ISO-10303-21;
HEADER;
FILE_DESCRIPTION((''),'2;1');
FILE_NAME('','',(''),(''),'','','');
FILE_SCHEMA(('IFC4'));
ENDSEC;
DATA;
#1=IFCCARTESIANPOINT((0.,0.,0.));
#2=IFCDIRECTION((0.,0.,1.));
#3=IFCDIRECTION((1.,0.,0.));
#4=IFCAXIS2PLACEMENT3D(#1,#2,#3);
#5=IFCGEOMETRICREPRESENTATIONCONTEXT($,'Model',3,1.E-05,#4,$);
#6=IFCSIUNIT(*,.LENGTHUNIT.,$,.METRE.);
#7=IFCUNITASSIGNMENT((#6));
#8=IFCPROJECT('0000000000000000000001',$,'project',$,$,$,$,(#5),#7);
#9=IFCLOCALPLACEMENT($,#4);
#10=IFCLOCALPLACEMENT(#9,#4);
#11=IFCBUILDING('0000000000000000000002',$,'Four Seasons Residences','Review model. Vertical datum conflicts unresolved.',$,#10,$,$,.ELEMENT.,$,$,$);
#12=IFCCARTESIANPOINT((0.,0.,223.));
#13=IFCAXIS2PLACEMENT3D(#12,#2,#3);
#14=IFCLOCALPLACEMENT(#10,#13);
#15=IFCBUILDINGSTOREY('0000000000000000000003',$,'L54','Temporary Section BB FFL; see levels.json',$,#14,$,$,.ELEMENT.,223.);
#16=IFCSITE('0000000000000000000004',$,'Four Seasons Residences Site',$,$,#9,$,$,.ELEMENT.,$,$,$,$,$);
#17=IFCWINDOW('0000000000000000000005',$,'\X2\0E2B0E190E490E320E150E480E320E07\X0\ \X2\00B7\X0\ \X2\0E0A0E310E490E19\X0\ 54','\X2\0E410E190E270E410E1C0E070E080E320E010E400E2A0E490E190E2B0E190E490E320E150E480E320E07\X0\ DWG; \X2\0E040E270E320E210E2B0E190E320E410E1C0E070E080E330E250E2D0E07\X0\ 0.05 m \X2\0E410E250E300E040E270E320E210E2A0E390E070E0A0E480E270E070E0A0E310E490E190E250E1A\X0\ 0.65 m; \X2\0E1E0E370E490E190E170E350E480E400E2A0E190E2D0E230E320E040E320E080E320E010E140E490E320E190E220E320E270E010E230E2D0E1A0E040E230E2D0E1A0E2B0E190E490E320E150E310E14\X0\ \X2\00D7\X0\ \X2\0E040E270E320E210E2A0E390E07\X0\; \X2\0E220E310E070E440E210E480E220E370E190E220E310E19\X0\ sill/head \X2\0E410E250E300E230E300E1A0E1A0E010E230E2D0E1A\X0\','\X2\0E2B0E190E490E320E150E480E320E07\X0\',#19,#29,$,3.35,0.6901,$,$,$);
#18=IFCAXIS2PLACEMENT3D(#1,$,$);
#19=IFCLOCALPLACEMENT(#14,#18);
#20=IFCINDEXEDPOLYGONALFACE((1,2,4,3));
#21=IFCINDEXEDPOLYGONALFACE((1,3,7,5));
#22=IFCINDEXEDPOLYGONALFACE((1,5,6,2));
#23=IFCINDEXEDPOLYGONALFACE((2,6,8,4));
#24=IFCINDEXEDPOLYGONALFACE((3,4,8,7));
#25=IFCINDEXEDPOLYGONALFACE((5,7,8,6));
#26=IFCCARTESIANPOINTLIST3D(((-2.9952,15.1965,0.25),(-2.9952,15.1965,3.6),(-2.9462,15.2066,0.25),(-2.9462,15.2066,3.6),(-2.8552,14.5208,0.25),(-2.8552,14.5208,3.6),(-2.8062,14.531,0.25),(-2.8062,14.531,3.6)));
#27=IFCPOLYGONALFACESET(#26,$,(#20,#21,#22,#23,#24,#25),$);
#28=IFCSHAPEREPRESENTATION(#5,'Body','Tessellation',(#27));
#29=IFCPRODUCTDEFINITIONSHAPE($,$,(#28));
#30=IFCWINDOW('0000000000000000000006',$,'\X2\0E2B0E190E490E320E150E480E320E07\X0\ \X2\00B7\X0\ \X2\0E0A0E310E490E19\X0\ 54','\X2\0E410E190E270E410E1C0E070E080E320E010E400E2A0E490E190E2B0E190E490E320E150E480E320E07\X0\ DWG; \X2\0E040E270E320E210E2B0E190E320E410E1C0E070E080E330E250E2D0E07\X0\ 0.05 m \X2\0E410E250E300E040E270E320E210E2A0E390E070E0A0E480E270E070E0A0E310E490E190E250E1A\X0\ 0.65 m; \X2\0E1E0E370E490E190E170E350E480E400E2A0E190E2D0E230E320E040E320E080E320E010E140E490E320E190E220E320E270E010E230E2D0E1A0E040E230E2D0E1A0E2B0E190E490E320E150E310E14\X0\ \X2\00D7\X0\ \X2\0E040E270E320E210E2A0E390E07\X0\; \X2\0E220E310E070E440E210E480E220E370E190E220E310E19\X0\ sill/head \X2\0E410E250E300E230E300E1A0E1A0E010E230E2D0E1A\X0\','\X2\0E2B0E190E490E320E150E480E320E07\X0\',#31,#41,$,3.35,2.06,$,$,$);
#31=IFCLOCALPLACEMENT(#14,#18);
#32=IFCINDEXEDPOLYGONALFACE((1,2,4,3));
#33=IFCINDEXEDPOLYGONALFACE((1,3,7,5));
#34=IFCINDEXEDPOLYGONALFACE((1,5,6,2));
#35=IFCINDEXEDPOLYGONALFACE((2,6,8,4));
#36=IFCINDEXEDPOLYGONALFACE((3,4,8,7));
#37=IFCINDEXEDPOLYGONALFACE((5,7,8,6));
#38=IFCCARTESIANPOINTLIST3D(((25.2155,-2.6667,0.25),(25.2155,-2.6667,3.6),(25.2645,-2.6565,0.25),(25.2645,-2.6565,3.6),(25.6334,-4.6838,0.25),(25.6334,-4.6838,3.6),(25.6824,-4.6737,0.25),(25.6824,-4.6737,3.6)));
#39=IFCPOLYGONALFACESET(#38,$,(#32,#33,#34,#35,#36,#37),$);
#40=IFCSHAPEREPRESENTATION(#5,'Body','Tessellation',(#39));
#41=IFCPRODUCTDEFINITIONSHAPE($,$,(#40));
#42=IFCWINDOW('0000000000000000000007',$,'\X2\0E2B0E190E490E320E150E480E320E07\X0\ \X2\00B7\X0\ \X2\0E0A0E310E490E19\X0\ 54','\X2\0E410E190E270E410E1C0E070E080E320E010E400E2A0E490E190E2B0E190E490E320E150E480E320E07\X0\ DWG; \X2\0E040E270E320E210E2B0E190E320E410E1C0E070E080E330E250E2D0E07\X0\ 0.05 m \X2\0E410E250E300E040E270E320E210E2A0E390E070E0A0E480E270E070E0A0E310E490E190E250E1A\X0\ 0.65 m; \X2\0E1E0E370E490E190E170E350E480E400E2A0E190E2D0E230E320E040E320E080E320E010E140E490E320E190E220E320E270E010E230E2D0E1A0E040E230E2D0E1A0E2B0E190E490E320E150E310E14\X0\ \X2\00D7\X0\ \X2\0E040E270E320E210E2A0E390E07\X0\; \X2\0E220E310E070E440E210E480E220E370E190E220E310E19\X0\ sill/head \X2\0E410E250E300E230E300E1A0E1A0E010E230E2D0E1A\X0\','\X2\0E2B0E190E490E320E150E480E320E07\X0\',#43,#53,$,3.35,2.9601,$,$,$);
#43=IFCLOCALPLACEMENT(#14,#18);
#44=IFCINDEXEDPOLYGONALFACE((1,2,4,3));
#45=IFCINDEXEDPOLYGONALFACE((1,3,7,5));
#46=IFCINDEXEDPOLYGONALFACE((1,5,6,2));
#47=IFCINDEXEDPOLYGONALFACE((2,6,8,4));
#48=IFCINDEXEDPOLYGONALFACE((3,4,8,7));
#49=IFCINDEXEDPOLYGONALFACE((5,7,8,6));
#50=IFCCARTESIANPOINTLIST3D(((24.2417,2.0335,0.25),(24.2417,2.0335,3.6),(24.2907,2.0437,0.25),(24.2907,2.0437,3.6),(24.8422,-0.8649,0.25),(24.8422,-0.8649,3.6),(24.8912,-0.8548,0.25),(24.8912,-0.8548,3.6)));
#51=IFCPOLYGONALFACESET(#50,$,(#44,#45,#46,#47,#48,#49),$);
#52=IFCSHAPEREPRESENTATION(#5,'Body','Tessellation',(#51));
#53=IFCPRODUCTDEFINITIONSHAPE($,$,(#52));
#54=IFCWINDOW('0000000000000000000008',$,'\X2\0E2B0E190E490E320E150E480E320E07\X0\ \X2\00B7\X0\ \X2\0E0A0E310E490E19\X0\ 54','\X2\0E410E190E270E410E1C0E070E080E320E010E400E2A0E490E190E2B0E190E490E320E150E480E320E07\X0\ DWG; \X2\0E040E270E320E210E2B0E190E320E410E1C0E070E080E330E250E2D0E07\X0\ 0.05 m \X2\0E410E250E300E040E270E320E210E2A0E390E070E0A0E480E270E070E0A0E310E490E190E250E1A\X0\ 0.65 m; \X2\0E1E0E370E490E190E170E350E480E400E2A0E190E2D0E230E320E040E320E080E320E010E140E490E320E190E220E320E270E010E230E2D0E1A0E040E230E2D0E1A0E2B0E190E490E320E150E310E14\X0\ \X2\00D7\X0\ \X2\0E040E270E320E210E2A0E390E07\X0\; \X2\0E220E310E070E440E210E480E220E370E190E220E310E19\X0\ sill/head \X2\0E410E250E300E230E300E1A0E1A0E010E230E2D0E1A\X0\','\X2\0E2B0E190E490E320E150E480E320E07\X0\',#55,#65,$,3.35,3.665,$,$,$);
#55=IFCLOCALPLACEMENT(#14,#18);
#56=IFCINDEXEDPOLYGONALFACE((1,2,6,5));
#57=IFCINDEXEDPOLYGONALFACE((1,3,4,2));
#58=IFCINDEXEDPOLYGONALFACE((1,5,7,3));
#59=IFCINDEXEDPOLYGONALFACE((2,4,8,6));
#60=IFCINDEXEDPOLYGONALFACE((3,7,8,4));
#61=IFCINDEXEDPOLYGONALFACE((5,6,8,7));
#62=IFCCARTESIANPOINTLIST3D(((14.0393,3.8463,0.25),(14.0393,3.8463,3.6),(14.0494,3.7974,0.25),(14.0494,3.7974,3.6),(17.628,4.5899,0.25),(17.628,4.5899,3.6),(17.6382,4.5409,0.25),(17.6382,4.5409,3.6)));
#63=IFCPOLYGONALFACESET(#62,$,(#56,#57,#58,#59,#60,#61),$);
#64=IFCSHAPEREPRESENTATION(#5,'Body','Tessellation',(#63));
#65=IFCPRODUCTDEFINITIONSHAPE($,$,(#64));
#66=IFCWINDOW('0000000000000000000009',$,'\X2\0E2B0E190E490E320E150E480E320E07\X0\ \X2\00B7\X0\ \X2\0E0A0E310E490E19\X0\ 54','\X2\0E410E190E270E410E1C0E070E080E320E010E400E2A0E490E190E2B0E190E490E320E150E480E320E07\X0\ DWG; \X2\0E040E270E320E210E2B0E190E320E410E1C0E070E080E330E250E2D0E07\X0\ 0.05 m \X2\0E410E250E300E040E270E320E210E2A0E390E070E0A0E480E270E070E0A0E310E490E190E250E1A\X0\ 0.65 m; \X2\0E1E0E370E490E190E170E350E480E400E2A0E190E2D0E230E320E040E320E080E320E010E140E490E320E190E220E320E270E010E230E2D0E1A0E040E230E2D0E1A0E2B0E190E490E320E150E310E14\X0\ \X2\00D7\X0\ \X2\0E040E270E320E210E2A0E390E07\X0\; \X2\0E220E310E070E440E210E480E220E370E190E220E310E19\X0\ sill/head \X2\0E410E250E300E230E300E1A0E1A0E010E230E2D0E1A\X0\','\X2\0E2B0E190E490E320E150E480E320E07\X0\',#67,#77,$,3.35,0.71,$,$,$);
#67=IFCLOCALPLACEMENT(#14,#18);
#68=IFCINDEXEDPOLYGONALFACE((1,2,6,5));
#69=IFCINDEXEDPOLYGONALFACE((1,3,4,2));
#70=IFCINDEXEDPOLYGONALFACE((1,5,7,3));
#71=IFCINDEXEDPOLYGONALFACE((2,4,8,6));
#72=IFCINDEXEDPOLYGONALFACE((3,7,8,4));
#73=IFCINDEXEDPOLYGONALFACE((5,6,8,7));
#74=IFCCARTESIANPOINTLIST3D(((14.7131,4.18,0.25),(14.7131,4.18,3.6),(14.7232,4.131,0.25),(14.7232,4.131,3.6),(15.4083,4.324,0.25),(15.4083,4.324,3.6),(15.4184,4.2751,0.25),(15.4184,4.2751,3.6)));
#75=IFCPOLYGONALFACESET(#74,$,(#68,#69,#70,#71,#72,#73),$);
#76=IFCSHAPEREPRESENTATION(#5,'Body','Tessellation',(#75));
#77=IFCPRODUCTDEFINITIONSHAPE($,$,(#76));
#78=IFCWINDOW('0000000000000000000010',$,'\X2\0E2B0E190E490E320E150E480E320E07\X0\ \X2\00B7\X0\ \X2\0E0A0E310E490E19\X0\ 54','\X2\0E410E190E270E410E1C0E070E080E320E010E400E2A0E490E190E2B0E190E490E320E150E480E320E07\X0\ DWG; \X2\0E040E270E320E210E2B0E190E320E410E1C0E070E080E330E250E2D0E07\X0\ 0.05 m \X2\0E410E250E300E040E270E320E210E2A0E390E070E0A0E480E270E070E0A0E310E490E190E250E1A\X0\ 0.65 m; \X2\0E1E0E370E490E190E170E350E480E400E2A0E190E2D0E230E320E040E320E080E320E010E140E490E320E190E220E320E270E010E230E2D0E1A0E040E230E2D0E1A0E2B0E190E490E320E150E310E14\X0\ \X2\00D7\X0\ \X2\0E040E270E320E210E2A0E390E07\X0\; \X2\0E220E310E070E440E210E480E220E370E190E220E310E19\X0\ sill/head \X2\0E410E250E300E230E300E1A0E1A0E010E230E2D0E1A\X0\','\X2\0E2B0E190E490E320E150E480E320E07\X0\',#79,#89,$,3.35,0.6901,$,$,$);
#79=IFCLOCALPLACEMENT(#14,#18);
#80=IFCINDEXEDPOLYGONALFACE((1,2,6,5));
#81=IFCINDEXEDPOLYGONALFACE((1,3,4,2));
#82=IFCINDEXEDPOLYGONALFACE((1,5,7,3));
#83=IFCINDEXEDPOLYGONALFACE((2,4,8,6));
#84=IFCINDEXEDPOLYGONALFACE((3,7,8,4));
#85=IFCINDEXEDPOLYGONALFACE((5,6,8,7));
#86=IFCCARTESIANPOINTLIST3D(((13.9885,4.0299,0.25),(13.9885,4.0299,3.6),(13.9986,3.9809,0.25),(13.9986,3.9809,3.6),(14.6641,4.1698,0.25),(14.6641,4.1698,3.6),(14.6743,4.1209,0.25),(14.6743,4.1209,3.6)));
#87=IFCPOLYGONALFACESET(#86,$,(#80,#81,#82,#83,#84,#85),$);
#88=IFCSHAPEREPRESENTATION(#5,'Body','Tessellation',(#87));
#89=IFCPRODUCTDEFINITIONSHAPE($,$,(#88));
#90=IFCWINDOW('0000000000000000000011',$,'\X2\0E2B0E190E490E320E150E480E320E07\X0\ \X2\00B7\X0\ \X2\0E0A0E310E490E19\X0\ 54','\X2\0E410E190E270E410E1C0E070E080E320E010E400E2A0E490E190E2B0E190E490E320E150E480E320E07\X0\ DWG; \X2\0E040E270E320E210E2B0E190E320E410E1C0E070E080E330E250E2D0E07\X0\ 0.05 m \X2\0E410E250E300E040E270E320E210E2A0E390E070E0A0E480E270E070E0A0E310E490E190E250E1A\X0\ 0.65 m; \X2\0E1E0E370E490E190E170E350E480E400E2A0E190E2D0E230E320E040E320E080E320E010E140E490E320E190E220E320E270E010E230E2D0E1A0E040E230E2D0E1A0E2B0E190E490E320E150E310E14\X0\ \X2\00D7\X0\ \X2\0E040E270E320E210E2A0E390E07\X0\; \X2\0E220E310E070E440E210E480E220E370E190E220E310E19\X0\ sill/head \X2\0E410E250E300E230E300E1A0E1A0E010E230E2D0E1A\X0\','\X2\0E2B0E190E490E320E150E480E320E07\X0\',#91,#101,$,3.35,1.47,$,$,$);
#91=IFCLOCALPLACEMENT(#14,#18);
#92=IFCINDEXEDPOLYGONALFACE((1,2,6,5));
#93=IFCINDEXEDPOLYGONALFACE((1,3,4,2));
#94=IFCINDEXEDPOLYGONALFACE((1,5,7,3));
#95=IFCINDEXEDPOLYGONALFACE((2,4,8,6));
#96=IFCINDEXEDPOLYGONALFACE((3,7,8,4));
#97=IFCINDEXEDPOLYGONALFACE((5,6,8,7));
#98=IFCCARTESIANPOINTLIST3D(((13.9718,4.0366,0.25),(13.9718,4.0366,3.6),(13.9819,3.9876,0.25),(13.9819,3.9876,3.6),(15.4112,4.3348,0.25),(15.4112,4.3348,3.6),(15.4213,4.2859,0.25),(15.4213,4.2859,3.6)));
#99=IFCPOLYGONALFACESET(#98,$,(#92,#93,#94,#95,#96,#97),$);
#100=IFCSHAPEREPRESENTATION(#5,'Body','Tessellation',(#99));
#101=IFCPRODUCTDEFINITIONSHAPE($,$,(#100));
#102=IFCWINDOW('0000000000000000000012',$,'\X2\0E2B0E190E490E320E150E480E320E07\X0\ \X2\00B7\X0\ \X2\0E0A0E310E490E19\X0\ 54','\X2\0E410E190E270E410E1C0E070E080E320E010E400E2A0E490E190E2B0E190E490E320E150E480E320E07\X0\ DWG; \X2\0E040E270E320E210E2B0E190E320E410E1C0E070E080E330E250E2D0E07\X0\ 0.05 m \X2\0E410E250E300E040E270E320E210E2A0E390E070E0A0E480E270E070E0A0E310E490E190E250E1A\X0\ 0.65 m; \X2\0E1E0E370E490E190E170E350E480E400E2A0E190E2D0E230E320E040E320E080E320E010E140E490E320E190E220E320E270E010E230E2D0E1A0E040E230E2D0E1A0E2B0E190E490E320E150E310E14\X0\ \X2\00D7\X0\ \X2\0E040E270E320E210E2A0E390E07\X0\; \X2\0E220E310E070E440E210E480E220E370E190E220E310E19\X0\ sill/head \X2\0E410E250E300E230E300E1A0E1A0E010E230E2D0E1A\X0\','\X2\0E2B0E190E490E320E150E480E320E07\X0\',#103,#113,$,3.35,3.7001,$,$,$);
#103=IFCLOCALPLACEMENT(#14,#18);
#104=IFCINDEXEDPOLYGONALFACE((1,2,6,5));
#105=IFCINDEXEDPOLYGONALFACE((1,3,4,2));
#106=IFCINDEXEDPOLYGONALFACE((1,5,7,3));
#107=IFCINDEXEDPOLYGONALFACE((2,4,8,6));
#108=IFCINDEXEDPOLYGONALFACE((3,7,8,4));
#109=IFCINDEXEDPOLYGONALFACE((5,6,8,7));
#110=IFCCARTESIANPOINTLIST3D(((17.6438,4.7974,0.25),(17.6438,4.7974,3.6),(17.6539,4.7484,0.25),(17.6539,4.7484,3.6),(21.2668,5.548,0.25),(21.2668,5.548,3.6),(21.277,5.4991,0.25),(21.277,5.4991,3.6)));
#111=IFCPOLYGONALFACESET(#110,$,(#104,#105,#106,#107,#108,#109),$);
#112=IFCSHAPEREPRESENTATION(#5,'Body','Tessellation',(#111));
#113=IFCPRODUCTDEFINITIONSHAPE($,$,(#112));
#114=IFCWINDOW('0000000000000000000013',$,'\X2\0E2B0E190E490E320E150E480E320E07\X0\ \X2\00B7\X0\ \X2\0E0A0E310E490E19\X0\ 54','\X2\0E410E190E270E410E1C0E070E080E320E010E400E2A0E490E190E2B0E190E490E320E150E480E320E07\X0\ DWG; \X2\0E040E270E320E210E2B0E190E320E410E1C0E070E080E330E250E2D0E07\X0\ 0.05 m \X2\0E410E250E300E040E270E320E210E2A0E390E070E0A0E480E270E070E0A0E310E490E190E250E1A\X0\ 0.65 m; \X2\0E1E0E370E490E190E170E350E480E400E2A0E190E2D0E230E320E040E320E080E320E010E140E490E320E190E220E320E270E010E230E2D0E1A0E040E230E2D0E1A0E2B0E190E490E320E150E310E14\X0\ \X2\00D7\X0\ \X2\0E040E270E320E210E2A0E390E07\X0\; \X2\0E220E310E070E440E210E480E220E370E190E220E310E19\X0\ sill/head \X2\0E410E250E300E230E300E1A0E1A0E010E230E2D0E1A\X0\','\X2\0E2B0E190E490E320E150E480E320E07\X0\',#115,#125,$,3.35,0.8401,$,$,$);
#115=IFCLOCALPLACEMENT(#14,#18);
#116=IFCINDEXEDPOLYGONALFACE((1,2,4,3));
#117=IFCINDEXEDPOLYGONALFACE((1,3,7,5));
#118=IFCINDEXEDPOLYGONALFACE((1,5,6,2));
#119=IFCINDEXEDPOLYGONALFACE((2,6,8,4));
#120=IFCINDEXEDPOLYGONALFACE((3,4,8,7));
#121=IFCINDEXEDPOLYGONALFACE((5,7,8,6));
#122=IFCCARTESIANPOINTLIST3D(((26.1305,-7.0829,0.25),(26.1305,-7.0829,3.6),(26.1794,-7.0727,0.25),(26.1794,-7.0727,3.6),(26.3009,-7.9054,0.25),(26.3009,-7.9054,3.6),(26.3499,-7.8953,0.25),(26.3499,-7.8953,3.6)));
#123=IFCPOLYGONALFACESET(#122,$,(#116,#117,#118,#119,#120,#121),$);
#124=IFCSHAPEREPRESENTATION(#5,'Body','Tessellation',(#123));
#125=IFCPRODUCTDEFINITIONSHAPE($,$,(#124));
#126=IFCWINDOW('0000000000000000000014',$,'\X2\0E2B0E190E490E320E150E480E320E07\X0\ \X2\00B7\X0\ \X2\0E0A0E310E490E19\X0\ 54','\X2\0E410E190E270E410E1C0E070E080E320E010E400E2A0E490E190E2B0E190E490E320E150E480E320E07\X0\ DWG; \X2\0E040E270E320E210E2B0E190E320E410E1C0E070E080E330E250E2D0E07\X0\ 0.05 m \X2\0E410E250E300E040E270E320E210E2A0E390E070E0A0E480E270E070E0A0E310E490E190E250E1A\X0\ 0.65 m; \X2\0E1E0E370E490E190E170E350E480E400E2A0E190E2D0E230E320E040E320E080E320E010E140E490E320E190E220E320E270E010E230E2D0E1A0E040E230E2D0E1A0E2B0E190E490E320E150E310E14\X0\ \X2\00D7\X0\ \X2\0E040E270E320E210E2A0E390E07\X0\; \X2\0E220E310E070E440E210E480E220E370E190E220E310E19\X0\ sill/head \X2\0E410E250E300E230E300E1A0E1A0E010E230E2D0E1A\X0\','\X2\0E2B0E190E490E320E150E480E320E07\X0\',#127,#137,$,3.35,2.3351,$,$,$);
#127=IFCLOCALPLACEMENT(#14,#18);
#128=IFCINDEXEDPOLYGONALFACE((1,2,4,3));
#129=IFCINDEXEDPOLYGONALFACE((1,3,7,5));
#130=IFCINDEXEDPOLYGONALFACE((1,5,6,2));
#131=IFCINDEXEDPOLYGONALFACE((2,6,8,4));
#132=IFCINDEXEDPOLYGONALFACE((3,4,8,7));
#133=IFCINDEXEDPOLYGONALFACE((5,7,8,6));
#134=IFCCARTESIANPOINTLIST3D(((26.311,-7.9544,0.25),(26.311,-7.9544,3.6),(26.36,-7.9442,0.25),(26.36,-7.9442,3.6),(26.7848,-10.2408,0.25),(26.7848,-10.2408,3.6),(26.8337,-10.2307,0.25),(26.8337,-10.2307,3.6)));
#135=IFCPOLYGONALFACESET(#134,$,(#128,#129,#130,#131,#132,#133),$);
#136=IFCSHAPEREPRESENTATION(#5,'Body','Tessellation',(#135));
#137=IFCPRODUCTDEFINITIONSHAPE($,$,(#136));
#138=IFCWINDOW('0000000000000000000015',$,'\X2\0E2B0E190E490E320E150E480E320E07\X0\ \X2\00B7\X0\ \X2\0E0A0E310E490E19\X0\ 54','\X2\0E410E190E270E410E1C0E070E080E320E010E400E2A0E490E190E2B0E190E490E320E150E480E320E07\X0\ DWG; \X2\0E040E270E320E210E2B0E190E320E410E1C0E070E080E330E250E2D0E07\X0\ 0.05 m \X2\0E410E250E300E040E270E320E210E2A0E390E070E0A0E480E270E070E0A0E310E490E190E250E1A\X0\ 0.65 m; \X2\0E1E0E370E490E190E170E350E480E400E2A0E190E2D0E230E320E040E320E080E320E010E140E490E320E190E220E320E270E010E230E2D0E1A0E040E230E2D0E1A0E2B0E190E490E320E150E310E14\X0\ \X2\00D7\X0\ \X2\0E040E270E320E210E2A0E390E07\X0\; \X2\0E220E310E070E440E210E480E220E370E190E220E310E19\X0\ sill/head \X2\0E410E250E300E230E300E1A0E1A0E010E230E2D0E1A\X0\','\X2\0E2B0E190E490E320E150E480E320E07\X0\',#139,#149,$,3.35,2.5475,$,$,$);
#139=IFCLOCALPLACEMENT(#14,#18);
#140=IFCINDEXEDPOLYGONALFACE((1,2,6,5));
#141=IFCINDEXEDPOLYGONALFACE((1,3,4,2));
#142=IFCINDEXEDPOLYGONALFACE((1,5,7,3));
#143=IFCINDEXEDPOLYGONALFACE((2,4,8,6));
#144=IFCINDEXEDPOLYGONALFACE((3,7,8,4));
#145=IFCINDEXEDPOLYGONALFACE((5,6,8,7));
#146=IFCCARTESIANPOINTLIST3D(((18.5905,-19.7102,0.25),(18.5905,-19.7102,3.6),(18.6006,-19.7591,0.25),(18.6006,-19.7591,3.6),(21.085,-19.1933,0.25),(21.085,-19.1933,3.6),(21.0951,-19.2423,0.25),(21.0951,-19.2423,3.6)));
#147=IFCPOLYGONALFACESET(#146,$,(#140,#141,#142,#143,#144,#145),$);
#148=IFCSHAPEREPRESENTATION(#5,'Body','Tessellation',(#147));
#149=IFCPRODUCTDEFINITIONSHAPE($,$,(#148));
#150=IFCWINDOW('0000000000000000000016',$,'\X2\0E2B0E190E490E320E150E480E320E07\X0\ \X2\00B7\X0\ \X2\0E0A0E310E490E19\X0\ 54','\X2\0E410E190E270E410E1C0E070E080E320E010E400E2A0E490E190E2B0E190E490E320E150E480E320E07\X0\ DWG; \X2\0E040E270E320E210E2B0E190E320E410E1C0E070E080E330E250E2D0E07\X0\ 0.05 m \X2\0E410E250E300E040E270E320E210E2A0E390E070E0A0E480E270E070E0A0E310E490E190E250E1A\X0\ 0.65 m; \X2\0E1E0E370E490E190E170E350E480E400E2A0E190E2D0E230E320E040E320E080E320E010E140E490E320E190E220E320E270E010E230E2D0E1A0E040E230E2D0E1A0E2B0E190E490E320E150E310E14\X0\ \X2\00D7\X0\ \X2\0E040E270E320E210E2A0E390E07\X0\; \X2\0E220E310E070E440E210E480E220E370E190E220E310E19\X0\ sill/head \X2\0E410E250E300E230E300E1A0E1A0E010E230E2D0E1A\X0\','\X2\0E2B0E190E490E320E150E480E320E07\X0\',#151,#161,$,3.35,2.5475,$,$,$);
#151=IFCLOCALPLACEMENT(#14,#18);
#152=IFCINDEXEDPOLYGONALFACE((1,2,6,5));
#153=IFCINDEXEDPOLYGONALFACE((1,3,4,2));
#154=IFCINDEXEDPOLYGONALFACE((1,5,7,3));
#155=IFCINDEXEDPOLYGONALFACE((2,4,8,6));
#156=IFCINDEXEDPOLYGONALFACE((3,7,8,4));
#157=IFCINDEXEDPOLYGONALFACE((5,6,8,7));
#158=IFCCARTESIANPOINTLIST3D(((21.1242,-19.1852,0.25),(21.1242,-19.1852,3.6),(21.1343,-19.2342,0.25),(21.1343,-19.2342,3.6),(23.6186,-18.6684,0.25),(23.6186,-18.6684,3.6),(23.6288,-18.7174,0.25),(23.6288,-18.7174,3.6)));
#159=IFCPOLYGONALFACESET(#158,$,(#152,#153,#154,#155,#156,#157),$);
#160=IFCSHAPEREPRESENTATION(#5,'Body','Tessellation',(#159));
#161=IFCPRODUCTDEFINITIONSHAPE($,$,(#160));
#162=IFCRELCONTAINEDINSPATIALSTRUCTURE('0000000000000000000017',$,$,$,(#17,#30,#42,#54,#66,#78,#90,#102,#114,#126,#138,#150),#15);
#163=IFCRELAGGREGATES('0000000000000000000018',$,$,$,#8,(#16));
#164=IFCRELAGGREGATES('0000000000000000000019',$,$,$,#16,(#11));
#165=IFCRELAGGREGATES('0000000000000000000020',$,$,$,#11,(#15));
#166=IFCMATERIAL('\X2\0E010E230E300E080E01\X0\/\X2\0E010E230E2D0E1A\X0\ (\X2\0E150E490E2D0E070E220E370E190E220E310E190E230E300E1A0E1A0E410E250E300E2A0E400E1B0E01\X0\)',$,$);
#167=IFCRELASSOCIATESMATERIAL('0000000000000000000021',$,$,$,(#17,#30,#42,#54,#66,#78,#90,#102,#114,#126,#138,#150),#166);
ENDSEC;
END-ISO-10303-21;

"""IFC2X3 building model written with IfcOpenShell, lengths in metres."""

from ifc_helpers import new_model, si_unit, frame, origin_with_axes, place, context, project, spatial, polyline, outline, extrude, material, element, save


model = new_model("IFC2X3")

# Units and contexts
model_context = context("Model", 3, precision=1e-05, world=origin_with_axes())
ifc_project = project(units=[si_unit("LENGTHUNIT", "METRE")], contexts=[model_context])

# Site, building, storey
site_placement = place(None, origin_with_axes())
site = spatial("IfcSite", under=ifc_project, at=site_placement, Name="Four Seasons Residences Site", CompositionType="ELEMENT")
building_placement = place(site_placement, origin_with_axes())
building = spatial("IfcBuilding", under=site, at=building_placement, Name="Four Seasons Residences", Description="Review model. Vertical datum conflicts unresolved.", CompositionType="ELEMENT")
storey_placement = place(building_placement, frame((0.0, 0.0, 223.0), z_axis=(0.0, 0.0, 1.0), x_axis=(1.0, 0.0, 0.0)))
storey = spatial("IfcBuildingStorey", under=building, at=storey_placement, Name="L54", Description="Temporary Section BB FFL; see levels.json", CompositionType="ELEMENT", Elevation=223.0)

# Windows
ifc_material = material(Name="กระจก/กรอบ (ต้องยืนยันระบบและสเปก)")
window_1_placement = place(storey_placement, origin_with_axes())
element("IfcWindow", 1, at=window_1_placement, inside=storey, material=ifc_material, Name="หน้าต่าง · ชั้น 54", Description="แนวแผงจากเส้นหน้าต่าง DWG; ความหนาแผงจำลอง 0.05 m และความสูงช่วงชั้นลบ 0.65 m; พื้นที่เสนอราคาจากด้านยาวกรอบครอบหน้าตัด × ความสูง; ยังไม่ยืนยัน sill/head และระบบกรอบ", ObjectType="หน้าต่าง", OverallHeight=3.35, OverallWidth=0.6901, context=model_context, shape_type="SweptSolid", body=[
    extrude(outline(polyline([(-2.9952, 15.1965), (-2.9462, 15.2066), (-2.8062, 14.531), (-2.8552, 14.5208), (-2.9952, 15.1965)])), frame((0.0, 0.0, 0.25), z_axis=(0.0, 0.0, 1.0), x_axis=(1.0, 0.0, 0.0)), (0.0, 0.0, 1.0), 3.35),
])
window_2_placement = place(storey_placement, origin_with_axes())
element("IfcWindow", 2, at=window_2_placement, inside=storey, material=ifc_material, Name="หน้าต่าง · ชั้น 54", Description="แนวแผงจากเส้นหน้าต่าง DWG; ความหนาแผงจำลอง 0.05 m และความสูงช่วงชั้นลบ 0.65 m; พื้นที่เสนอราคาจากด้านยาวกรอบครอบหน้าตัด × ความสูง; ยังไม่ยืนยัน sill/head และระบบกรอบ", ObjectType="หน้าต่าง", OverallHeight=3.35, OverallWidth=2.06, context=model_context, shape_type="SweptSolid", body=[
    extrude(outline(polyline([(25.2155, -2.6667), (25.2645, -2.6565), (25.6824, -4.6737), (25.6334, -4.6838), (25.2155, -2.6667)])), frame((0.0, 0.0, 0.25), z_axis=(0.0, 0.0, 1.0), x_axis=(1.0, 0.0, 0.0)), (0.0, 0.0, 1.0), 3.35),
])
window_3_placement = place(storey_placement, origin_with_axes())
element("IfcWindow", 3, at=window_3_placement, inside=storey, material=ifc_material, Name="หน้าต่าง · ชั้น 54", Description="แนวแผงจากเส้นหน้าต่าง DWG; ความหนาแผงจำลอง 0.05 m และความสูงช่วงชั้นลบ 0.65 m; พื้นที่เสนอราคาจากด้านยาวกรอบครอบหน้าตัด × ความสูง; ยังไม่ยืนยัน sill/head และระบบกรอบ", ObjectType="หน้าต่าง", OverallHeight=3.35, OverallWidth=2.9601, context=model_context, shape_type="SweptSolid", body=[
    extrude(outline(polyline([(24.2417, 2.0335), (24.2907, 2.0437), (24.8912, -0.8548), (24.8422, -0.8649), (24.2417, 2.0335)])), frame((0.0, 0.0, 0.25), z_axis=(0.0, 0.0, 1.0), x_axis=(1.0, 0.0, 0.0)), (0.0, 0.0, 1.0), 3.35),
])
window_4_placement = place(storey_placement, origin_with_axes())
element("IfcWindow", 4, at=window_4_placement, inside=storey, material=ifc_material, Name="หน้าต่าง · ชั้น 54", Description="แนวแผงจากเส้นหน้าต่าง DWG; ความหนาแผงจำลอง 0.05 m และความสูงช่วงชั้นลบ 0.65 m; พื้นที่เสนอราคาจากด้านยาวกรอบครอบหน้าตัด × ความสูง; ยังไม่ยืนยัน sill/head และระบบกรอบ", ObjectType="หน้าต่าง", OverallHeight=3.35, OverallWidth=3.665, context=model_context, shape_type="SweptSolid", body=[
    extrude(outline(polyline([(14.0494, 3.7974), (14.0393, 3.8463), (17.628, 4.5899), (17.6382, 4.5409), (14.0494, 3.7974)])), frame((0.0, 0.0, 0.25), z_axis=(0.0, 0.0, 1.0), x_axis=(1.0, 0.0, 0.0)), (0.0, 0.0, 1.0), 3.35),
])
window_5_placement = place(storey_placement, origin_with_axes())
element("IfcWindow", 5, at=window_5_placement, inside=storey, material=ifc_material, Name="หน้าต่าง · ชั้น 54", Description="แนวแผงจากเส้นหน้าต่าง DWG; ความหนาแผงจำลอง 0.05 m และความสูงช่วงชั้นลบ 0.65 m; พื้นที่เสนอราคาจากด้านยาวกรอบครอบหน้าตัด × ความสูง; ยังไม่ยืนยัน sill/head และระบบกรอบ", ObjectType="หน้าต่าง", OverallHeight=3.35, OverallWidth=0.71, context=model_context, shape_type="SweptSolid", body=[
    extrude(outline(polyline([(14.7232, 4.131), (14.7131, 4.18), (15.4083, 4.324), (15.4184, 4.2751), (14.7232, 4.131)])), frame((0.0, 0.0, 0.25), z_axis=(0.0, 0.0, 1.0), x_axis=(1.0, 0.0, 0.0)), (0.0, 0.0, 1.0), 3.35),
])
window_6_placement = place(storey_placement, origin_with_axes())
element("IfcWindow", 6, at=window_6_placement, inside=storey, material=ifc_material, Name="หน้าต่าง · ชั้น 54", Description="แนวแผงจากเส้นหน้าต่าง DWG; ความหนาแผงจำลอง 0.05 m และความสูงช่วงชั้นลบ 0.65 m; พื้นที่เสนอราคาจากด้านยาวกรอบครอบหน้าตัด × ความสูง; ยังไม่ยืนยัน sill/head และระบบกรอบ", ObjectType="หน้าต่าง", OverallHeight=3.35, OverallWidth=0.6901, context=model_context, shape_type="SweptSolid", body=[
    extrude(outline(polyline([(13.9986, 3.9809), (13.9885, 4.0299), (14.6641, 4.1698), (14.6743, 4.1209), (13.9986, 3.9809)])), frame((0.0, 0.0, 0.25), z_axis=(0.0, 0.0, 1.0), x_axis=(1.0, 0.0, 0.0)), (0.0, 0.0, 1.0), 3.35),
])
window_7_placement = place(storey_placement, origin_with_axes())
element("IfcWindow", 7, at=window_7_placement, inside=storey, material=ifc_material, Name="หน้าต่าง · ชั้น 54", Description="แนวแผงจากเส้นหน้าต่าง DWG; ความหนาแผงจำลอง 0.05 m และความสูงช่วงชั้นลบ 0.65 m; พื้นที่เสนอราคาจากด้านยาวกรอบครอบหน้าตัด × ความสูง; ยังไม่ยืนยัน sill/head และระบบกรอบ", ObjectType="หน้าต่าง", OverallHeight=3.35, OverallWidth=1.47, context=model_context, shape_type="SweptSolid", body=[
    extrude(outline(polyline([(13.9819, 3.9876), (13.9718, 4.0366), (15.4112, 4.3348), (15.4213, 4.2859), (13.9819, 3.9876)])), frame((0.0, 0.0, 0.25), z_axis=(0.0, 0.0, 1.0), x_axis=(1.0, 0.0, 0.0)), (0.0, 0.0, 1.0), 3.35),
])
window_8_placement = place(storey_placement, origin_with_axes())
element("IfcWindow", 8, at=window_8_placement, inside=storey, material=ifc_material, Name="หน้าต่าง · ชั้น 54", Description="แนวแผงจากเส้นหน้าต่าง DWG; ความหนาแผงจำลอง 0.05 m และความสูงช่วงชั้นลบ 0.65 m; พื้นที่เสนอราคาจากด้านยาวกรอบครอบหน้าตัด × ความสูง; ยังไม่ยืนยัน sill/head และระบบกรอบ", ObjectType="หน้าต่าง", OverallHeight=3.35, OverallWidth=3.7001, context=model_context, shape_type="SweptSolid", body=[
    extrude(outline(polyline([(17.6539, 4.7484), (17.6438, 4.7974), (21.2668, 5.548), (21.277, 5.4991), (17.6539, 4.7484)])), frame((0.0, 0.0, 0.25), z_axis=(0.0, 0.0, 1.0), x_axis=(1.0, 0.0, 0.0)), (0.0, 0.0, 1.0), 3.35),
])
window_9_placement = place(storey_placement, origin_with_axes())
element("IfcWindow", 9, at=window_9_placement, inside=storey, material=ifc_material, Name="หน้าต่าง · ชั้น 54", Description="แนวแผงจากเส้นหน้าต่าง DWG; ความหนาแผงจำลอง 0.05 m และความสูงช่วงชั้นลบ 0.65 m; พื้นที่เสนอราคาจากด้านยาวกรอบครอบหน้าตัด × ความสูง; ยังไม่ยืนยัน sill/head และระบบกรอบ", ObjectType="หน้าต่าง", OverallHeight=3.35, OverallWidth=0.8401, context=model_context, shape_type="SweptSolid", body=[
    extrude(outline(polyline([(26.1305, -7.0829), (26.1794, -7.0727), (26.3499, -7.8953), (26.3009, -7.9054), (26.1305, -7.0829)])), frame((0.0, 0.0, 0.25), z_axis=(0.0, 0.0, 1.0), x_axis=(1.0, 0.0, 0.0)), (0.0, 0.0, 1.0), 3.35),
])
window_10_placement = place(storey_placement, origin_with_axes())
element("IfcWindow", 10, at=window_10_placement, inside=storey, material=ifc_material, Name="หน้าต่าง · ชั้น 54", Description="แนวแผงจากเส้นหน้าต่าง DWG; ความหนาแผงจำลอง 0.05 m และความสูงช่วงชั้นลบ 0.65 m; พื้นที่เสนอราคาจากด้านยาวกรอบครอบหน้าตัด × ความสูง; ยังไม่ยืนยัน sill/head และระบบกรอบ", ObjectType="หน้าต่าง", OverallHeight=3.35, OverallWidth=2.3351, context=model_context, shape_type="SweptSolid", body=[
    extrude(outline(polyline([(26.311, -7.9544), (26.36, -7.9442), (26.8337, -10.2307), (26.7848, -10.2408), (26.311, -7.9544)])), frame((0.0, 0.0, 0.25), z_axis=(0.0, 0.0, 1.0), x_axis=(1.0, 0.0, 0.0)), (0.0, 0.0, 1.0), 3.35),
])
window_11_placement = place(storey_placement, origin_with_axes())
element("IfcWindow", 11, at=window_11_placement, inside=storey, material=ifc_material, Name="หน้าต่าง · ชั้น 54", Description="แนวแผงจากเส้นหน้าต่าง DWG; ความหนาแผงจำลอง 0.05 m และความสูงช่วงชั้นลบ 0.65 m; พื้นที่เสนอราคาจากด้านยาวกรอบครอบหน้าตัด × ความสูง; ยังไม่ยืนยัน sill/head และระบบกรอบ", ObjectType="หน้าต่าง", OverallHeight=3.35, OverallWidth=2.5475, context=model_context, shape_type="SweptSolid", body=[
    extrude(outline(polyline([(18.6006, -19.7591), (18.5905, -19.7102), (21.085, -19.1933), (21.0951, -19.2423), (18.6006, -19.7591)])), frame((0.0, 0.0, 0.25), z_axis=(0.0, 0.0, 1.0), x_axis=(1.0, 0.0, 0.0)), (0.0, 0.0, 1.0), 3.35),
])
window_12_placement = place(storey_placement, origin_with_axes())
element("IfcWindow", 12, at=window_12_placement, inside=storey, material=ifc_material, Name="หน้าต่าง · ชั้น 54", Description="แนวแผงจากเส้นหน้าต่าง DWG; ความหนาแผงจำลอง 0.05 m และความสูงช่วงชั้นลบ 0.65 m; พื้นที่เสนอราคาจากด้านยาวกรอบครอบหน้าตัด × ความสูง; ยังไม่ยืนยัน sill/head และระบบกรอบ", ObjectType="หน้าต่าง", OverallHeight=3.35, OverallWidth=2.5475, context=model_context, shape_type="SweptSolid", body=[
    extrude(outline(polyline([(21.1343, -19.2342), (21.1242, -19.1852), (23.6186, -18.6684), (23.6288, -18.7174), (21.1343, -19.2342)])), frame((0.0, 0.0, 0.25), z_axis=(0.0, 0.0, 1.0), x_axis=(1.0, 0.0, 0.0)), (0.0, 0.0, 1.0), 3.35),
])

save(model, "model.ifc")
